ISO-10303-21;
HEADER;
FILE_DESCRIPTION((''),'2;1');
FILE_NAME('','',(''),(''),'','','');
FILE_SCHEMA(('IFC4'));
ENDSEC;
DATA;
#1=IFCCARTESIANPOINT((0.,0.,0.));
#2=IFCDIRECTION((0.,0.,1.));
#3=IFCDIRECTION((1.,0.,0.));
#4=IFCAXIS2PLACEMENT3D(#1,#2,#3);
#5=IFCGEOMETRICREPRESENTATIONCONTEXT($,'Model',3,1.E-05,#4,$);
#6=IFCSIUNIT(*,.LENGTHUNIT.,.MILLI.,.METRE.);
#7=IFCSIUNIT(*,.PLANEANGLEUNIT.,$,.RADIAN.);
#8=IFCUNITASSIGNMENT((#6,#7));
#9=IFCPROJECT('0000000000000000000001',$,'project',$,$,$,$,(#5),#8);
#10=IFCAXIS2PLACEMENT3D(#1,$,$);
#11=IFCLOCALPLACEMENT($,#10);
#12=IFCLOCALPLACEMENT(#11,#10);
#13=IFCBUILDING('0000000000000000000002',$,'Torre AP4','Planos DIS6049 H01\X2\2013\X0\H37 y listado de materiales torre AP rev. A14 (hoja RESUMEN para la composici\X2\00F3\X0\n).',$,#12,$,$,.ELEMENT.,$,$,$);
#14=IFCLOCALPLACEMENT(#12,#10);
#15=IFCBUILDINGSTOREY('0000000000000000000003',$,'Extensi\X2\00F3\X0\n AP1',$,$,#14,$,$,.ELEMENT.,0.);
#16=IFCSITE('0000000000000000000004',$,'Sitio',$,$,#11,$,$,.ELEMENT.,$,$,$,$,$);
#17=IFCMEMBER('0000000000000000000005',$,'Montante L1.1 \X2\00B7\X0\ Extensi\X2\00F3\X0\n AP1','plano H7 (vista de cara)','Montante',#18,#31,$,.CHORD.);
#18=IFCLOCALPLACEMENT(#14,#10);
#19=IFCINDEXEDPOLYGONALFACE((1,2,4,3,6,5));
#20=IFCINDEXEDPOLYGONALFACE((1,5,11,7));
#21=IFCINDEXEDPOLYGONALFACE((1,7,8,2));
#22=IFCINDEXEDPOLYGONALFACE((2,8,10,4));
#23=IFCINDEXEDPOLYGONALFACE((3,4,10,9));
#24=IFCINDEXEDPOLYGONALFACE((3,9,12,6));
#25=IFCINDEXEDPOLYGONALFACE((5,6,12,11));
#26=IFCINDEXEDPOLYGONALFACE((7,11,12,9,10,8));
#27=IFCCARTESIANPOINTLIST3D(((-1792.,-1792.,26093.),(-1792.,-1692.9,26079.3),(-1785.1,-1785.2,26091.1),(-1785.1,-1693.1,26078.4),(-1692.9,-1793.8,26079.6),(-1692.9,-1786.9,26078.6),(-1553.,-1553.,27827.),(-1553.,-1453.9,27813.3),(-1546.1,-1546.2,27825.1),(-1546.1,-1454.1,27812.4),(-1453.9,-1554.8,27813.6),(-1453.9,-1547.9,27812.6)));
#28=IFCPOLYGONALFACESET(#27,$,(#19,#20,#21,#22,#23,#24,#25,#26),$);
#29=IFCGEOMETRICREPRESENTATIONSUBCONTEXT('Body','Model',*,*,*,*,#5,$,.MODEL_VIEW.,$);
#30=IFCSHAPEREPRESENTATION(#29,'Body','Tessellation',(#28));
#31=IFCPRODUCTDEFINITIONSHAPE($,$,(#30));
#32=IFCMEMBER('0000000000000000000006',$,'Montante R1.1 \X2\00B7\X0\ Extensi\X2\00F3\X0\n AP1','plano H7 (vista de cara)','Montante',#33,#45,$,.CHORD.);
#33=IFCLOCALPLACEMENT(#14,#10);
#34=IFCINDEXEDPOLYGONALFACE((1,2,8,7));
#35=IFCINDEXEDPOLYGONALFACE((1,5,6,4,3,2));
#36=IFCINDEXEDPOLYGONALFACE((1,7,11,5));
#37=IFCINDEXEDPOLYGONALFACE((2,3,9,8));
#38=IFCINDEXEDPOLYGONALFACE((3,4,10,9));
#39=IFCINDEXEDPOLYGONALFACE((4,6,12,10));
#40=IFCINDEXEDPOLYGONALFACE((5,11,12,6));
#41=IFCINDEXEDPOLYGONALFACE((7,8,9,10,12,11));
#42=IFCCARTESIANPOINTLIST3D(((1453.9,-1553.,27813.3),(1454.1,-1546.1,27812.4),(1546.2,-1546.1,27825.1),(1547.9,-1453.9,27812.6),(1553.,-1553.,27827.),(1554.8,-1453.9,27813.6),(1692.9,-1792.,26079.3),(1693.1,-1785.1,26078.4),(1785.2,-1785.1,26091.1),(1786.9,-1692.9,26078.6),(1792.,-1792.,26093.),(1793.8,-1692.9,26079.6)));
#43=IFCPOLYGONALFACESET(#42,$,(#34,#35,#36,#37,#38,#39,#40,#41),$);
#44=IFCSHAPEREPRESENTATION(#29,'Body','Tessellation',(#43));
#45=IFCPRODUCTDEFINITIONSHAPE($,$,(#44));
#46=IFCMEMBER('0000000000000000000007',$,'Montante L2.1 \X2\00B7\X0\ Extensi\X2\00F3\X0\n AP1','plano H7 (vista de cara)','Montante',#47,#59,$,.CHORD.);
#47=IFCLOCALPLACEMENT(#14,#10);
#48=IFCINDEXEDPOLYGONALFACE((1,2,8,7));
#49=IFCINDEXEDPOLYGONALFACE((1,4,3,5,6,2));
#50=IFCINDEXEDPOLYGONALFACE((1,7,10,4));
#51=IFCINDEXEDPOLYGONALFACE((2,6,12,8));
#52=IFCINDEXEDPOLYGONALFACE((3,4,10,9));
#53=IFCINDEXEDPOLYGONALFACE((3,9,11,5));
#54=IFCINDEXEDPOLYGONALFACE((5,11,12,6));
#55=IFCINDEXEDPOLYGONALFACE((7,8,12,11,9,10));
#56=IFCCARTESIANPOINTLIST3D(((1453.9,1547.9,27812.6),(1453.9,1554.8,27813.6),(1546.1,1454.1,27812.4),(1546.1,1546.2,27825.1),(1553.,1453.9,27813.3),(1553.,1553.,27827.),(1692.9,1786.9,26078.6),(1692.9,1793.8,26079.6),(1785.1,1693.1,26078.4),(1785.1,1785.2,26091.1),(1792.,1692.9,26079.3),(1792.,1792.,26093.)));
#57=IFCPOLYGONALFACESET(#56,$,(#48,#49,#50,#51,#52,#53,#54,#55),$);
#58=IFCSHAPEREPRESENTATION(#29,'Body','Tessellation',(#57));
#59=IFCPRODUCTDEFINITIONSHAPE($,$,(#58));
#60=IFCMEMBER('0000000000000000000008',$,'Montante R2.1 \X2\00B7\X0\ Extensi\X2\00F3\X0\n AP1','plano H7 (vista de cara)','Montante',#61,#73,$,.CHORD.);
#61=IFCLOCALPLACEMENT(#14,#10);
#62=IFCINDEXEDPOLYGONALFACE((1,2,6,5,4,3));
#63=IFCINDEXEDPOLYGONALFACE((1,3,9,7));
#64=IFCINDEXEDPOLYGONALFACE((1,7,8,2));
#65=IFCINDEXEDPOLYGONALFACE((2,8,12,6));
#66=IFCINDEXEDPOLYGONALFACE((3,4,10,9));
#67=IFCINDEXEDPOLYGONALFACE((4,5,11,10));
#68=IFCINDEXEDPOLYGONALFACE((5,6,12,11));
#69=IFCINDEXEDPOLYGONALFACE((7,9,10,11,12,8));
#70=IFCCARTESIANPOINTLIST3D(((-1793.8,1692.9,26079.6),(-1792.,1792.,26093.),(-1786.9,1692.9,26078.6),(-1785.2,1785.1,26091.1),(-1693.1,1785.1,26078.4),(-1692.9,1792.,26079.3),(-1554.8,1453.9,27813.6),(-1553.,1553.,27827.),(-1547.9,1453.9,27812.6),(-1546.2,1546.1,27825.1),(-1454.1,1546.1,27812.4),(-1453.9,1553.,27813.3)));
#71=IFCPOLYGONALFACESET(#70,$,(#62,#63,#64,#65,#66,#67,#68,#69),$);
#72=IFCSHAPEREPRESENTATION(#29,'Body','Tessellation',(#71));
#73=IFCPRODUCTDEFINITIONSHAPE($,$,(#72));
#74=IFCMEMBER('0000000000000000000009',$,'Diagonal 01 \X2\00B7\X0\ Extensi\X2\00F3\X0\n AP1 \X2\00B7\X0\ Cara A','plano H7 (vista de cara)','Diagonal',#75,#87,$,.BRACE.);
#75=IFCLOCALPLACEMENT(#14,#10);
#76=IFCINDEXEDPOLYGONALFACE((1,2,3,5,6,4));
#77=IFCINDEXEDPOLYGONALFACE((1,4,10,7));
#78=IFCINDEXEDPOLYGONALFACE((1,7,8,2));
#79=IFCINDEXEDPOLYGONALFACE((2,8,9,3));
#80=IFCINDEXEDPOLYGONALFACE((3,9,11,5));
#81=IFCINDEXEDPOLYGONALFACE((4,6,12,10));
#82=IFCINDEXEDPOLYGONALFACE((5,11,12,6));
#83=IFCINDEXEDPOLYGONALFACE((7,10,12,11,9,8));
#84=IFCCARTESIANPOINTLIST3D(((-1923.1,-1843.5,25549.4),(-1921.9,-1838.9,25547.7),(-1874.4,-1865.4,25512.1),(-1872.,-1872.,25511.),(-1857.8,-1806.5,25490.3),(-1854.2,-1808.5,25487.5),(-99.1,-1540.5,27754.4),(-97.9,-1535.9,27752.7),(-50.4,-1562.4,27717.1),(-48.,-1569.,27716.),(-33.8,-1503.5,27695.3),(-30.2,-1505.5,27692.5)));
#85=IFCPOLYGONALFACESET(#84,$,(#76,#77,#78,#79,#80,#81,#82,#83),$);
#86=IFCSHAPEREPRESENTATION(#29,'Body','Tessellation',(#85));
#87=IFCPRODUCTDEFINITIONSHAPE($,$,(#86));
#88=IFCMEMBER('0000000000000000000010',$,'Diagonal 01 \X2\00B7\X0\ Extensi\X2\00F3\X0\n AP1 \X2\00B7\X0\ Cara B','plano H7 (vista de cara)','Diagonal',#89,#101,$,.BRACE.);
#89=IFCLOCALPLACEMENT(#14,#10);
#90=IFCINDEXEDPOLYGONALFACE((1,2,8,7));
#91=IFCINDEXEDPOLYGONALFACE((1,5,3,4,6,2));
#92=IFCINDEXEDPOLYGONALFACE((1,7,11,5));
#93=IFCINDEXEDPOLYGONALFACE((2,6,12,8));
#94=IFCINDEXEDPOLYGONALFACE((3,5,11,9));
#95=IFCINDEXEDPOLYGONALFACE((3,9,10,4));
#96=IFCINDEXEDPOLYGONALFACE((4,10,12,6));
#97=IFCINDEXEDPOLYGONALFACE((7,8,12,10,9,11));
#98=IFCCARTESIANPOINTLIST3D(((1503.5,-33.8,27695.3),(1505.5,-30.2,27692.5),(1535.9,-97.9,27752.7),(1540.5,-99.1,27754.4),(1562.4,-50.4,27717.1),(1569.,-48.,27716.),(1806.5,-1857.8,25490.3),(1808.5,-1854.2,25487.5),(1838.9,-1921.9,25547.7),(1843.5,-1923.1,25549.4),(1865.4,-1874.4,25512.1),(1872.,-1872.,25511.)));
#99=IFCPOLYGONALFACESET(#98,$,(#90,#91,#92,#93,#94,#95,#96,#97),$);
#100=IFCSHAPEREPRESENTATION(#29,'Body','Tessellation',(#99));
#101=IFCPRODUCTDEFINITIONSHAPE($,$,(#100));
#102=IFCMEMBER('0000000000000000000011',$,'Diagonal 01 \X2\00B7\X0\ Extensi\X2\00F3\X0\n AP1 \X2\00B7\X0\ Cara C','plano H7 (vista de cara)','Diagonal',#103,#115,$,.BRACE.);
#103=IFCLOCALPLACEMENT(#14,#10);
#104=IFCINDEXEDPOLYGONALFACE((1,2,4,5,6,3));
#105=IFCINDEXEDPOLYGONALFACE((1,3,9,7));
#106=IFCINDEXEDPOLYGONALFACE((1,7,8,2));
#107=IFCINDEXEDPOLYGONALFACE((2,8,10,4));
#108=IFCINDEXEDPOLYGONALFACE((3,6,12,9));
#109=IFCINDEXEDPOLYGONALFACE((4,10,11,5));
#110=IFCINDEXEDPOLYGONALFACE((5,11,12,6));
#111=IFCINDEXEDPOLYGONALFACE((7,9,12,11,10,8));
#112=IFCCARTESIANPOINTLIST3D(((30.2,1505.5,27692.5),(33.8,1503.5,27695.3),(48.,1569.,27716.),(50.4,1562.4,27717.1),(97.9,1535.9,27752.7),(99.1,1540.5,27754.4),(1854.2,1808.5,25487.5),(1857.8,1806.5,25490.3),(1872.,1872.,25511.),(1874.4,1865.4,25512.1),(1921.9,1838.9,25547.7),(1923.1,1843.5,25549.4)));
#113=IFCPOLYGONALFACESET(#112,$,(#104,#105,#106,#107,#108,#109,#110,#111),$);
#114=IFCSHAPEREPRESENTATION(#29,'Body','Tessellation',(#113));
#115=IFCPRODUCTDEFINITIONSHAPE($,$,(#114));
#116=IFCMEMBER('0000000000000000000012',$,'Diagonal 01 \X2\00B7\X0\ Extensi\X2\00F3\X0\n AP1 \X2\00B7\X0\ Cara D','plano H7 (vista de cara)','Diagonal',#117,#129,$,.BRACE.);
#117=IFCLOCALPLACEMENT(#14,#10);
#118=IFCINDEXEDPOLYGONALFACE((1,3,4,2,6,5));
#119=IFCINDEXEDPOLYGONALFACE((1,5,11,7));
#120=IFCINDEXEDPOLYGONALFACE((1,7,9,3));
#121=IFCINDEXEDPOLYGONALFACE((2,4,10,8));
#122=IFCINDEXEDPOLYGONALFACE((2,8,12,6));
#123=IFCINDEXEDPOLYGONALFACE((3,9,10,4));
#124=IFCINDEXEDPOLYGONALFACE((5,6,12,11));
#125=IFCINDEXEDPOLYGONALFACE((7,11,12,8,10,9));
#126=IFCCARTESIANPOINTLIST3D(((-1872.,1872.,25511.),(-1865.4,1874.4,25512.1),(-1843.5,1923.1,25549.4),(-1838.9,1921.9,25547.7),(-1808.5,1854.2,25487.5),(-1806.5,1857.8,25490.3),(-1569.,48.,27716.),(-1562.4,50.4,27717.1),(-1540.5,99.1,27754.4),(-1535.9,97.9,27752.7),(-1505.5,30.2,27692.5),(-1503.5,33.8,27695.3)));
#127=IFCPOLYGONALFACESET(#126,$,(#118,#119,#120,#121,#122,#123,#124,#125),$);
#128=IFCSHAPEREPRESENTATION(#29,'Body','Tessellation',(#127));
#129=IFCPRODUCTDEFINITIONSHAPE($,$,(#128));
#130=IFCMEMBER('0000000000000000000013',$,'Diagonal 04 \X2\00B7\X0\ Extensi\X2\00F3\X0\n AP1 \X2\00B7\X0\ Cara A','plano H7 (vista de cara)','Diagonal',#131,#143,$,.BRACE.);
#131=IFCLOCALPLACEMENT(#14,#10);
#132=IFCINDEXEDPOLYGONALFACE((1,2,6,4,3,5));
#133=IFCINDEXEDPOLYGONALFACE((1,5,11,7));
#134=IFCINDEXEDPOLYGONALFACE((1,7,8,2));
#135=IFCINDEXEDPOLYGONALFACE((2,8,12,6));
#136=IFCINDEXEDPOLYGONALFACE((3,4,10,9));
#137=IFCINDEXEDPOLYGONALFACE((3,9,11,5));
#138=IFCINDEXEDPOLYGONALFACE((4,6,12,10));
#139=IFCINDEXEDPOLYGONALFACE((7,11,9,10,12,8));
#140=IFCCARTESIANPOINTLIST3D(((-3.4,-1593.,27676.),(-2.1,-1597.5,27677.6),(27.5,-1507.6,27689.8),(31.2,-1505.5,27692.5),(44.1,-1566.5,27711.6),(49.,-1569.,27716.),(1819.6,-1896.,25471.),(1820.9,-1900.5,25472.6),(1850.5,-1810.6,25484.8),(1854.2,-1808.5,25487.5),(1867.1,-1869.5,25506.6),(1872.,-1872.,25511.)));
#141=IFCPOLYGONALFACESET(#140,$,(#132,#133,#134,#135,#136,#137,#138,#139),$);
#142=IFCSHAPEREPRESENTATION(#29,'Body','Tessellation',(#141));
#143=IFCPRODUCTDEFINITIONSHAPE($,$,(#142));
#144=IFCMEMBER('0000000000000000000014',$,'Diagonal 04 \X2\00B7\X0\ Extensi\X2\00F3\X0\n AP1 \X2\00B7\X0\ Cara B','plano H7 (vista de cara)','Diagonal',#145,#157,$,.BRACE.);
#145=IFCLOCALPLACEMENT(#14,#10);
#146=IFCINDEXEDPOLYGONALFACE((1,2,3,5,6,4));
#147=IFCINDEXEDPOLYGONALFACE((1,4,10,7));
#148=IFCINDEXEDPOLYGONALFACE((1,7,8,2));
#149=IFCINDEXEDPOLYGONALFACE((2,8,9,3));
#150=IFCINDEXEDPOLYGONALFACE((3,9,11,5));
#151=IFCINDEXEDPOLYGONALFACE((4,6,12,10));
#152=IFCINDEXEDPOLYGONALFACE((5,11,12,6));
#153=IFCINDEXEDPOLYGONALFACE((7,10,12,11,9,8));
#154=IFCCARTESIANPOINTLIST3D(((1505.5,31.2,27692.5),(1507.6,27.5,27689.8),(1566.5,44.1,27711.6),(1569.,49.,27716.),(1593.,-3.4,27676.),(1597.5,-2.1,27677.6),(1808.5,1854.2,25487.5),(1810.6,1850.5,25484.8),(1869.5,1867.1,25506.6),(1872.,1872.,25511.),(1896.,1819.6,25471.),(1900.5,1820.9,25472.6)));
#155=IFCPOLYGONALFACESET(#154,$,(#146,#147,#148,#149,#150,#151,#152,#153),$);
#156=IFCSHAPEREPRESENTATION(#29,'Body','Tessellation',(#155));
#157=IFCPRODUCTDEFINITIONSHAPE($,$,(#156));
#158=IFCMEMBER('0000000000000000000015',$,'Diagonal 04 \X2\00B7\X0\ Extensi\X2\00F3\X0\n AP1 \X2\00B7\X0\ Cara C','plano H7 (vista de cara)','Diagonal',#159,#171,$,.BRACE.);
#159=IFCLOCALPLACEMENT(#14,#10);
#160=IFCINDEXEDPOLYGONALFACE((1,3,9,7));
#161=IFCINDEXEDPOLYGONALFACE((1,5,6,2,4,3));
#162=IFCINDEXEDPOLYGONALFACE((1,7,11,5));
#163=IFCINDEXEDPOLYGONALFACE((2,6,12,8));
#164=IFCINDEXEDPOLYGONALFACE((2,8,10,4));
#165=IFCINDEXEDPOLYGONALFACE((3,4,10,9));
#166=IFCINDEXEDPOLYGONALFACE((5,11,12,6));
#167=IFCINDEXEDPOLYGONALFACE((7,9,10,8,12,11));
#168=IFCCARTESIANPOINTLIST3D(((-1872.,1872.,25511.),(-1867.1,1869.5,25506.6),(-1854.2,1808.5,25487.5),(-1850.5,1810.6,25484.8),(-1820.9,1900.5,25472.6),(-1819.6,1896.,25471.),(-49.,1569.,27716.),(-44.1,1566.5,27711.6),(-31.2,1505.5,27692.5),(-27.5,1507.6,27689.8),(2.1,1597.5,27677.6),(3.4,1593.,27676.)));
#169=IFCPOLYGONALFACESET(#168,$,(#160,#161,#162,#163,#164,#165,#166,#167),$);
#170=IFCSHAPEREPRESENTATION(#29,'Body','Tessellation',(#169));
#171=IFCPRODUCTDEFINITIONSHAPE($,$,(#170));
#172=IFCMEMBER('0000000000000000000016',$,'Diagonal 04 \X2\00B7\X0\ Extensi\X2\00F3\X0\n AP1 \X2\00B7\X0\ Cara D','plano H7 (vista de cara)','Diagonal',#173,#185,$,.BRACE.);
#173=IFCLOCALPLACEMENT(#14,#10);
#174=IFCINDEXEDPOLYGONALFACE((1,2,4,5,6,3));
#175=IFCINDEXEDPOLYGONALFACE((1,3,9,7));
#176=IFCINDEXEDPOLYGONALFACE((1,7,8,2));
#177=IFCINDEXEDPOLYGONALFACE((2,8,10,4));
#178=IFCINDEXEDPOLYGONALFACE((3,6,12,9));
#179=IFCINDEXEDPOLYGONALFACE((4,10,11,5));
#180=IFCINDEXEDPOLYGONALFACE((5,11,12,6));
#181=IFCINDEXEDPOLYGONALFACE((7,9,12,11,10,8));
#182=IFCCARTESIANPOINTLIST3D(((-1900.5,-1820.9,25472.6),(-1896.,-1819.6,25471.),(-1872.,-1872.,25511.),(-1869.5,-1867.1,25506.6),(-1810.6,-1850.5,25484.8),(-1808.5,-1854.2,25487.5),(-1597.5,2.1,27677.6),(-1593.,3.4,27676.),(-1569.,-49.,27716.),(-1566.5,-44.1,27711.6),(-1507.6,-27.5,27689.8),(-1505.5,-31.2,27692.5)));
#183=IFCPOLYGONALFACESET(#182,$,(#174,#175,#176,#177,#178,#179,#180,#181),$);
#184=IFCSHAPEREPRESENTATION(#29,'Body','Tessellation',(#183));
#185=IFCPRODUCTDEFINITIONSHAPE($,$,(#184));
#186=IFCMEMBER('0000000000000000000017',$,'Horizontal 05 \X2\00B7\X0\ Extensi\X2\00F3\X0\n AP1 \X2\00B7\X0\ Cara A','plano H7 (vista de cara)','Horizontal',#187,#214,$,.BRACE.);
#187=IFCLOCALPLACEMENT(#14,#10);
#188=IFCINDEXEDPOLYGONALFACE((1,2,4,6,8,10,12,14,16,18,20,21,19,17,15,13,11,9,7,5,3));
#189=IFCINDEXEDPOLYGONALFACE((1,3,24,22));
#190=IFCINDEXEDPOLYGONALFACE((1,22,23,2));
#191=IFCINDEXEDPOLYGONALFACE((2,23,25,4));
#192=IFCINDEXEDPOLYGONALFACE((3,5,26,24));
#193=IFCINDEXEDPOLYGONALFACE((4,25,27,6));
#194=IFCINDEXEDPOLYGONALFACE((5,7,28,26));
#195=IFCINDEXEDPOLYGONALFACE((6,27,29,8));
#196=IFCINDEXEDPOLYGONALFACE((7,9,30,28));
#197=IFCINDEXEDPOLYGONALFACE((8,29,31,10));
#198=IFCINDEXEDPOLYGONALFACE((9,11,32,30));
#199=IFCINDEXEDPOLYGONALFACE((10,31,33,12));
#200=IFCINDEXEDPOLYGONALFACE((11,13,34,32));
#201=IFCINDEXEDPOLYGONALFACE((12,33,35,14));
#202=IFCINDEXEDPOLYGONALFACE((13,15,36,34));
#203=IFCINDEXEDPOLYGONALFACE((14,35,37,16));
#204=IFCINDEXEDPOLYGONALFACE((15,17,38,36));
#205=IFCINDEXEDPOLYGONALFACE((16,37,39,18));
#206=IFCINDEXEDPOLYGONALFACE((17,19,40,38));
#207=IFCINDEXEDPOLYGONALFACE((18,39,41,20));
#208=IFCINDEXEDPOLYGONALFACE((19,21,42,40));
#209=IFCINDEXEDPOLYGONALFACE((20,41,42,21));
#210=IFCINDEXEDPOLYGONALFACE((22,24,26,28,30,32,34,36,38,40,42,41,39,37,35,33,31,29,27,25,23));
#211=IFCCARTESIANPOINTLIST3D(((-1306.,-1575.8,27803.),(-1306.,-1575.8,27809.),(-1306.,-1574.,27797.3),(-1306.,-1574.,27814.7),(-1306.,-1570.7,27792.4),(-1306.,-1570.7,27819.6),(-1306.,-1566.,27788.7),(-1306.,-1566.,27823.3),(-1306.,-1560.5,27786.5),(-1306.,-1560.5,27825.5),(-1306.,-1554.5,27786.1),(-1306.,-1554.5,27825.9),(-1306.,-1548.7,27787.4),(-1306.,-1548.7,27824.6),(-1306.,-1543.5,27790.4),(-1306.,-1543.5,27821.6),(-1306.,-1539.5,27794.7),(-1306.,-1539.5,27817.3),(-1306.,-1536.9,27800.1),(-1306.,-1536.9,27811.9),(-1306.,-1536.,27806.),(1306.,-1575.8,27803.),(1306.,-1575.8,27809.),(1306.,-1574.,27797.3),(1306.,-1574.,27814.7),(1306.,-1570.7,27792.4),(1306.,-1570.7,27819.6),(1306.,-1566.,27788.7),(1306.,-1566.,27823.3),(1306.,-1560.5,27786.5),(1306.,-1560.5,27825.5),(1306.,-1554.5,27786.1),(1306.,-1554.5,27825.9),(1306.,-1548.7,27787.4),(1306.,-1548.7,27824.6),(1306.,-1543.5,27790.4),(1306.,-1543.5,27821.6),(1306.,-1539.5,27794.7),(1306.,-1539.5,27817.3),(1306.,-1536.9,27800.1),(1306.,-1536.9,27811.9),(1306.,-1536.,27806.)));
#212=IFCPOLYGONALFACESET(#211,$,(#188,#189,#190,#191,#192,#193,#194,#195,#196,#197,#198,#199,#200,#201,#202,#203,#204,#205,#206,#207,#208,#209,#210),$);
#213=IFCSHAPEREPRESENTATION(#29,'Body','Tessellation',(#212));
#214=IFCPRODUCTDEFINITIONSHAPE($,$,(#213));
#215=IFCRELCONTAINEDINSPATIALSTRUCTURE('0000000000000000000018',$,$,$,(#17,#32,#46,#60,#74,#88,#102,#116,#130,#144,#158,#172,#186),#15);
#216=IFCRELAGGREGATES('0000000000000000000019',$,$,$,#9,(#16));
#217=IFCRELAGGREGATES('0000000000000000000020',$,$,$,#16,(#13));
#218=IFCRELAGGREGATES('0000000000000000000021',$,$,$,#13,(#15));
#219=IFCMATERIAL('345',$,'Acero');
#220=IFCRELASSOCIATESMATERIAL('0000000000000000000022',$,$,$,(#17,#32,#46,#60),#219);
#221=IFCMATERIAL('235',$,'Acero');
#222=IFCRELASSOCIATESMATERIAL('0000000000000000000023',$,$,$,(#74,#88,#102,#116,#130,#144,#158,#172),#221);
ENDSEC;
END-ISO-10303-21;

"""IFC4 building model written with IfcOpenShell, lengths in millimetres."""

from ifc_helpers import new_model, si_unit, frame, frame_2d, origin, origin_with_axes, place, context, subcontext, project, spatial, circle, l_section, extrude, material, element, save


model = new_model("IFC4")

# Units and contexts
model_context = context("Model", 3, precision=1e-05, world=origin_with_axes())
body_context = subcontext(model_context, "Body", "Model", "MODEL_VIEW")
ifc_project = project(units=[si_unit("LENGTHUNIT", "METRE", prefix="MILLI"), si_unit("PLANEANGLEUNIT", "RADIAN")], contexts=[model_context])

# Site, building, storey
site_placement = place(None, origin())
site = spatial("IfcSite", under=ifc_project, at=site_placement, Name="Sitio", CompositionType="ELEMENT")
building_placement = place(site_placement, origin())
building = spatial("IfcBuilding", under=site, at=building_placement, Name="Torre AP4", Description="Planos DIS6049 H01–H37 y listado de materiales torre AP rev. A14 (hoja RESUMEN para la composición).", CompositionType="ELEMENT")
storey_placement = place(building_placement, origin())
storey = spatial("IfcBuildingStorey", under=building, at=storey_placement, Name="Extensión AP1", CompositionType="ELEMENT", Elevation=0.0)

# Members
ifc_material_1 = material(Name="345", Category="Acero")
for number, where, z_axis, x_axis, name in (
    (1, (-1792.0, -1792.0, 26093.0), (0.135285, 0.135285, 0.981527), (0.990807, -0.018472, -0.134018), "Montante L1.1 · Extensión AP1"),
    (2, (1792.0, -1792.0, 26093.0), (-0.135285, 0.135285, 0.981527), (0.018472, 0.990807, -0.134018), "Montante R1.1 · Extensión AP1"),
    (3, (1792.0, 1792.0, 26093.0), (-0.135285, -0.135285, 0.981527), (-0.990807, 0.018472, -0.134018), "Montante L2.1 · Extensión AP1"),
    (4, (-1792.0, 1792.0, 26093.0), (0.135285, -0.135285, 0.981527), (-0.018472, -0.990807, -0.134018), "Montante R2.1 · Extensión AP1"),
):
    element("IfcMember", number, at=place(storey_placement, frame(where, z_axis=z_axis, x_axis=x_axis)), inside=storey, material=ifc_material_1, Name=name, Description="plano H7 (vista de cara)", ObjectType="Montante", PredefinedType="CHORD", context=body_context, shape_type="SweptSolid", body=[
        extrude(l_section(Depth=100.0, Width=100.0, Thickness=7.0, at=frame_2d((50.0, 50.0))), None, (0.0, 0.0, 1.0), 1766.6),
    ])
ifc_material_2 = material(Name="235", Category="Acero")
for number, where, z_axis, x_axis, name in (
    (5, (-1872.0, -1872.0, 25511.0), (0.633853, 0.105295, 0.766253), (0.25455, 0.907102, -0.335216), "Diagonal 01 · Extensión AP1 · Cara A"),
    (6, (1872.0, -1872.0, 25511.0), (-0.105295, 0.633853, 0.766253), (-0.907102, 0.25455, -0.335216), "Diagonal 01 · Extensión AP1 · Cara B"),
    (7, (1872.0, 1872.0, 25511.0), (-0.633853, -0.105295, 0.766253), (-0.25455, -0.907102, -0.335216), "Diagonal 01 · Extensión AP1 · Cara C"),
    (8, (-1872.0, 1872.0, 25511.0), (0.105295, -0.633853, 0.766253), (0.907102, -0.25455, -0.335216), "Diagonal 01 · Extensión AP1 · Cara D"),
):
    element("IfcMember", number, at=place(storey_placement, frame(where, z_axis=z_axis, x_axis=x_axis)), inside=storey, material=ifc_material_2, Name=name, Description="plano H7 (vista de cara)", ObjectType="Diagonal", PredefinedType="BRACE", context=body_context, shape_type="SweptSolid", body=[
        extrude(l_section(Depth=70.0, Width=70.0, Thickness=5.0, at=frame_2d((35.0, 35.0))), None, (0.0, 0.0, 1.0), 2877.6),
    ])
for number, where, z_axis, x_axis, name in (
    (9, (1872.0, -1872.0, 25511.0), (-0.633645, 0.105318, 0.766422), (-0.254835, 0.906984, -0.33532), "Diagonal 04 · Extensión AP1 · Cara A"),
    (10, (1872.0, 1872.0, 25511.0), (-0.105318, -0.633645, 0.766422), (-0.906984, -0.254835, -0.33532), "Diagonal 04 · Extensión AP1 · Cara B"),
    (11, (-1872.0, 1872.0, 25511.0), (0.633645, -0.105318, 0.766422), (0.254835, -0.906984, -0.33532), "Diagonal 04 · Extensión AP1 · Cara C"),
    (12, (-1872.0, -1872.0, 25511.0), (0.105318, 0.633645, 0.766422), (0.906984, 0.254835, -0.33532), "Diagonal 04 · Extensión AP1 · Cara D"),
):
    element("IfcMember", number, at=place(storey_placement, frame(where, z_axis=z_axis, x_axis=x_axis)), inside=storey, material=ifc_material_2, Name=name, Description="plano H7 (vista de cara)", ObjectType="Diagonal", PredefinedType="BRACE", context=body_context, shape_type="SweptSolid", body=[
        extrude(l_section(Depth=70.0, Width=70.0, Thickness=5.0, at=frame_2d((35.0, 35.0))), None, (0.0, 0.0, 1.0), 2877.0),
    ])
for number, where, z_axis, x_axis, name in (
    (13, (1306.0, -1556.0, 27806.0), (-1.0, 0.0, 0.0), (0.0, 1.0, 0.0), "Horizontal 05 · Extensión AP1 · Cara A"),
):
    element("IfcMember", number, at=place(storey_placement, frame(where, z_axis=z_axis, x_axis=x_axis)), inside=storey, Name=name, Description="plano H7 (vista de cara)", ObjectType="Horizontal", PredefinedType="BRACE", context=body_context, shape_type="SweptSolid", body=[
        extrude(circle(Radius=20.0), None, (0.0, 0.0, 1.0), 2612.0),
    ])

save(model, "model.ifc")
